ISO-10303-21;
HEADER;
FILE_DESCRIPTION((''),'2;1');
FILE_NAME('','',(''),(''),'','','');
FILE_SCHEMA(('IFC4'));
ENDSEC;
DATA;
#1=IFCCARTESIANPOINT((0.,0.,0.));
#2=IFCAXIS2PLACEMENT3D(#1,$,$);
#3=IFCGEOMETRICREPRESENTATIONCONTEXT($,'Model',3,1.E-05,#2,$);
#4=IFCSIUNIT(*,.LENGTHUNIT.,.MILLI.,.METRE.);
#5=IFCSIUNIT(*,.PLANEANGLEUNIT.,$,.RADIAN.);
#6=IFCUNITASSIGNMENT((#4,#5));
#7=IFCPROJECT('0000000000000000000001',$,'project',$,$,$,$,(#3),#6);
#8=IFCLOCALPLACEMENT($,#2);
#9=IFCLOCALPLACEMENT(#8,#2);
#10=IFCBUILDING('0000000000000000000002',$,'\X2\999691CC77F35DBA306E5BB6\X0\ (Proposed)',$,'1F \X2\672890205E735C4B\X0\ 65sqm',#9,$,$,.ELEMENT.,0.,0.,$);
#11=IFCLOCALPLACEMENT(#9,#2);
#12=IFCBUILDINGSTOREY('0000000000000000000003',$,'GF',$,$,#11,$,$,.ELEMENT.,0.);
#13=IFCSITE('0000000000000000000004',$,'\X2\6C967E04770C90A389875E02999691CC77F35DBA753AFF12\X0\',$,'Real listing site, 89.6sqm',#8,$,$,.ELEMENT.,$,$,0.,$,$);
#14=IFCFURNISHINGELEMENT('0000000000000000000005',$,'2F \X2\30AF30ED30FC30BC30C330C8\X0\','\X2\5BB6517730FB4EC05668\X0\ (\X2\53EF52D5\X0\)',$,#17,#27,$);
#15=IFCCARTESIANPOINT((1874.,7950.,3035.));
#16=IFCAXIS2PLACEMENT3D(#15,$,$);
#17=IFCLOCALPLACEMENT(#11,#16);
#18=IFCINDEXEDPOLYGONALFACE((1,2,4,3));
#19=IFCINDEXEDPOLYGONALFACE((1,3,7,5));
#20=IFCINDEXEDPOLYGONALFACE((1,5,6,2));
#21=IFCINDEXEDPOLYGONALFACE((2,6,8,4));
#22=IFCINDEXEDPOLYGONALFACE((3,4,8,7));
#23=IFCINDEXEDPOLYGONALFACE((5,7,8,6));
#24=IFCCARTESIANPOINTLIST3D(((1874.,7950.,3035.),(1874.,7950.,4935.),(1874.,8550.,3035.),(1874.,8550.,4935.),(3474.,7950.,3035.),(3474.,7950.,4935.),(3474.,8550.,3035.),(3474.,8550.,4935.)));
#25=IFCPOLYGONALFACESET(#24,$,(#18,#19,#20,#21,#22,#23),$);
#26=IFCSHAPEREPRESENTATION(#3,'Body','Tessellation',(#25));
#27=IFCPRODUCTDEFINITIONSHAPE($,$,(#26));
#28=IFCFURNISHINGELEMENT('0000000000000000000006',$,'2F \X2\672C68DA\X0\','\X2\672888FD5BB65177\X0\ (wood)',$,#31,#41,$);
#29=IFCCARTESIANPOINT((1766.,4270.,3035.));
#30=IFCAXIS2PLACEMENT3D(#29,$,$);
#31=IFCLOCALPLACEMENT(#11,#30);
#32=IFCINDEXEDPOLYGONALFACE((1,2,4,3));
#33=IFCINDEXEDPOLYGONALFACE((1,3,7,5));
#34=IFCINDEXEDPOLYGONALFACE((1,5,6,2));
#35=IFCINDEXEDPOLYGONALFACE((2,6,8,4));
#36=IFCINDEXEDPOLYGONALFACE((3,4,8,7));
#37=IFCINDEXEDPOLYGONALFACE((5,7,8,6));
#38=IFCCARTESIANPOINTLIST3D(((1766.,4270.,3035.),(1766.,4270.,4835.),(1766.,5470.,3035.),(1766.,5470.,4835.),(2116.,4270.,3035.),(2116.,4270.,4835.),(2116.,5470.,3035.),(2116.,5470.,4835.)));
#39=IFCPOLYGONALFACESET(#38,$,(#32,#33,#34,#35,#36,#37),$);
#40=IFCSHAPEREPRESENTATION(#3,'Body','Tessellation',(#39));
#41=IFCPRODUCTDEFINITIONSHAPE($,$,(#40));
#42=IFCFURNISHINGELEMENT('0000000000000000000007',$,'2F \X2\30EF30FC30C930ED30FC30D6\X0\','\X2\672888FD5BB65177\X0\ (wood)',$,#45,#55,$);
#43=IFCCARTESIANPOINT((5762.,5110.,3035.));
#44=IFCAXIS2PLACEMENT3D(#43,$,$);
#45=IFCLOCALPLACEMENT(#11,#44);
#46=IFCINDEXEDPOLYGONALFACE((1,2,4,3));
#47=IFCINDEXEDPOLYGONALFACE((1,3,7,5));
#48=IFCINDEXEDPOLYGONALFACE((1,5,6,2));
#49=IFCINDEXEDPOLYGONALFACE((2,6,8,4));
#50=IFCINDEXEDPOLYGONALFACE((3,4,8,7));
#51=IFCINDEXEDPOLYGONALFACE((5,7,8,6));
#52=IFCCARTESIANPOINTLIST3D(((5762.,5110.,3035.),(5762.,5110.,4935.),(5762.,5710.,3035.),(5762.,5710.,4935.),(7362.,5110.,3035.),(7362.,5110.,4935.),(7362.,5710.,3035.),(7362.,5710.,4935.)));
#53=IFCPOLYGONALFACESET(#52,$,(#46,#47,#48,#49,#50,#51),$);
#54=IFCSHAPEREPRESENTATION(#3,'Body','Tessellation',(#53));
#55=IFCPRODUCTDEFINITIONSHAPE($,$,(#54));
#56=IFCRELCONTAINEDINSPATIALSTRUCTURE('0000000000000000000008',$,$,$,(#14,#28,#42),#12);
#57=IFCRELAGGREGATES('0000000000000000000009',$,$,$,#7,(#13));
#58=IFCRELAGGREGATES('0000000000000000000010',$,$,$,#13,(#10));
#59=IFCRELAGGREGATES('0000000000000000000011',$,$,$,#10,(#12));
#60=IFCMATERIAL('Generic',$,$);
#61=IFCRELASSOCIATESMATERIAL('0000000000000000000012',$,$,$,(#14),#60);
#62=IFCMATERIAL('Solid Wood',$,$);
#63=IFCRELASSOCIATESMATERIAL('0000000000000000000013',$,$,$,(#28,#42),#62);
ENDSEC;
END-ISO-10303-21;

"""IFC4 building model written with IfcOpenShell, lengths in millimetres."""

from ifc_helpers import new_model, si_unit, frame, frame_2d, origin, place, context, project, spatial, rectangle, extrude, material, element, save


model = new_model("IFC4")

# Units and contexts
model_context = context("Model", 3, precision=1e-05, world=origin())
ifc_project = project(units=[si_unit("LENGTHUNIT", "METRE", prefix="MILLI"), si_unit("PLANEANGLEUNIT", "RADIAN")], contexts=[model_context])

# Site, building, storey
site_placement = place(None, origin())
site = spatial("IfcSite", under=ifc_project, at=site_placement, Name="沖縄県那覇市首里石嶺町２", ObjectType="Real listing site, 89.6sqm", CompositionType="ELEMENT", RefElevation=0.0)
building_placement = place(site_placement, origin())
building = spatial("IfcBuilding", under=site, at=building_placement, Name="首里石嶺の家 (Proposed)", ObjectType="1F 木造平屋 65sqm", CompositionType="ELEMENT", ElevationOfRefHeight=0.0, ElevationOfTerrain=0.0)
storey_placement = place(building_placement, origin())
storey = spatial("IfcBuildingStorey", under=building, at=storey_placement, Name="GF", CompositionType="ELEMENT", Elevation=0.0)

# Shared definitions
ifc_material_1 = material(Name="Solid Wood")

# Shared definitions
ifc_material_2 = material(Name="Generic")

# Furnishing elements
furnishing_1_placement = place(storey_placement, frame((1874.0, 7950.0, 3035.0)))
element("IfcFurnishingElement", 1, at=furnishing_1_placement, inside=storey, material=ifc_material_2, Name="2F クローゼット", Description="家具・什器 (可動)", context=model_context, shape_type="SweptSolid", body=[
    extrude(rectangle(XDim=1600.0, YDim=600.0, at=frame_2d((800.0, 300.0))), frame((1874.0, 7950.0, 3035.0)), (0.0, 0.0, 1.0), 1900.0),
])
furnishing_2_placement = place(storey_placement, frame((1766.0, 4270.0, 3035.0)))
element("IfcFurnishingElement", 2, at=furnishing_2_placement, inside=storey, material=ifc_material_1, Name="2F 本棚", Description="木製家具 (wood)", context=model_context, shape_type="SweptSolid", body=[
    extrude(rectangle(XDim=350.0, YDim=1200.0, at=frame_2d((175.0, 600.0))), frame((1766.0, 4270.0, 3035.0)), (0.0, 0.0, 1.0), 1800.0),
])
furnishing_3_placement = place(storey_placement, frame((5762.0, 5110.0, 3035.0)))
element("IfcFurnishingElement", 3, at=furnishing_3_placement, inside=storey, material=ifc_material_1, Name="2F ワードローブ", Description="木製家具 (wood)", context=model_context, shape_type="SweptSolid", body=[
    extrude(rectangle(XDim=1600.0, YDim=600.0, at=frame_2d((800.0, 300.0))), frame((5762.0, 5110.0, 3035.0)), (0.0, 0.0, 1.0), 1900.0),
])

save(model, "model.ifc")
